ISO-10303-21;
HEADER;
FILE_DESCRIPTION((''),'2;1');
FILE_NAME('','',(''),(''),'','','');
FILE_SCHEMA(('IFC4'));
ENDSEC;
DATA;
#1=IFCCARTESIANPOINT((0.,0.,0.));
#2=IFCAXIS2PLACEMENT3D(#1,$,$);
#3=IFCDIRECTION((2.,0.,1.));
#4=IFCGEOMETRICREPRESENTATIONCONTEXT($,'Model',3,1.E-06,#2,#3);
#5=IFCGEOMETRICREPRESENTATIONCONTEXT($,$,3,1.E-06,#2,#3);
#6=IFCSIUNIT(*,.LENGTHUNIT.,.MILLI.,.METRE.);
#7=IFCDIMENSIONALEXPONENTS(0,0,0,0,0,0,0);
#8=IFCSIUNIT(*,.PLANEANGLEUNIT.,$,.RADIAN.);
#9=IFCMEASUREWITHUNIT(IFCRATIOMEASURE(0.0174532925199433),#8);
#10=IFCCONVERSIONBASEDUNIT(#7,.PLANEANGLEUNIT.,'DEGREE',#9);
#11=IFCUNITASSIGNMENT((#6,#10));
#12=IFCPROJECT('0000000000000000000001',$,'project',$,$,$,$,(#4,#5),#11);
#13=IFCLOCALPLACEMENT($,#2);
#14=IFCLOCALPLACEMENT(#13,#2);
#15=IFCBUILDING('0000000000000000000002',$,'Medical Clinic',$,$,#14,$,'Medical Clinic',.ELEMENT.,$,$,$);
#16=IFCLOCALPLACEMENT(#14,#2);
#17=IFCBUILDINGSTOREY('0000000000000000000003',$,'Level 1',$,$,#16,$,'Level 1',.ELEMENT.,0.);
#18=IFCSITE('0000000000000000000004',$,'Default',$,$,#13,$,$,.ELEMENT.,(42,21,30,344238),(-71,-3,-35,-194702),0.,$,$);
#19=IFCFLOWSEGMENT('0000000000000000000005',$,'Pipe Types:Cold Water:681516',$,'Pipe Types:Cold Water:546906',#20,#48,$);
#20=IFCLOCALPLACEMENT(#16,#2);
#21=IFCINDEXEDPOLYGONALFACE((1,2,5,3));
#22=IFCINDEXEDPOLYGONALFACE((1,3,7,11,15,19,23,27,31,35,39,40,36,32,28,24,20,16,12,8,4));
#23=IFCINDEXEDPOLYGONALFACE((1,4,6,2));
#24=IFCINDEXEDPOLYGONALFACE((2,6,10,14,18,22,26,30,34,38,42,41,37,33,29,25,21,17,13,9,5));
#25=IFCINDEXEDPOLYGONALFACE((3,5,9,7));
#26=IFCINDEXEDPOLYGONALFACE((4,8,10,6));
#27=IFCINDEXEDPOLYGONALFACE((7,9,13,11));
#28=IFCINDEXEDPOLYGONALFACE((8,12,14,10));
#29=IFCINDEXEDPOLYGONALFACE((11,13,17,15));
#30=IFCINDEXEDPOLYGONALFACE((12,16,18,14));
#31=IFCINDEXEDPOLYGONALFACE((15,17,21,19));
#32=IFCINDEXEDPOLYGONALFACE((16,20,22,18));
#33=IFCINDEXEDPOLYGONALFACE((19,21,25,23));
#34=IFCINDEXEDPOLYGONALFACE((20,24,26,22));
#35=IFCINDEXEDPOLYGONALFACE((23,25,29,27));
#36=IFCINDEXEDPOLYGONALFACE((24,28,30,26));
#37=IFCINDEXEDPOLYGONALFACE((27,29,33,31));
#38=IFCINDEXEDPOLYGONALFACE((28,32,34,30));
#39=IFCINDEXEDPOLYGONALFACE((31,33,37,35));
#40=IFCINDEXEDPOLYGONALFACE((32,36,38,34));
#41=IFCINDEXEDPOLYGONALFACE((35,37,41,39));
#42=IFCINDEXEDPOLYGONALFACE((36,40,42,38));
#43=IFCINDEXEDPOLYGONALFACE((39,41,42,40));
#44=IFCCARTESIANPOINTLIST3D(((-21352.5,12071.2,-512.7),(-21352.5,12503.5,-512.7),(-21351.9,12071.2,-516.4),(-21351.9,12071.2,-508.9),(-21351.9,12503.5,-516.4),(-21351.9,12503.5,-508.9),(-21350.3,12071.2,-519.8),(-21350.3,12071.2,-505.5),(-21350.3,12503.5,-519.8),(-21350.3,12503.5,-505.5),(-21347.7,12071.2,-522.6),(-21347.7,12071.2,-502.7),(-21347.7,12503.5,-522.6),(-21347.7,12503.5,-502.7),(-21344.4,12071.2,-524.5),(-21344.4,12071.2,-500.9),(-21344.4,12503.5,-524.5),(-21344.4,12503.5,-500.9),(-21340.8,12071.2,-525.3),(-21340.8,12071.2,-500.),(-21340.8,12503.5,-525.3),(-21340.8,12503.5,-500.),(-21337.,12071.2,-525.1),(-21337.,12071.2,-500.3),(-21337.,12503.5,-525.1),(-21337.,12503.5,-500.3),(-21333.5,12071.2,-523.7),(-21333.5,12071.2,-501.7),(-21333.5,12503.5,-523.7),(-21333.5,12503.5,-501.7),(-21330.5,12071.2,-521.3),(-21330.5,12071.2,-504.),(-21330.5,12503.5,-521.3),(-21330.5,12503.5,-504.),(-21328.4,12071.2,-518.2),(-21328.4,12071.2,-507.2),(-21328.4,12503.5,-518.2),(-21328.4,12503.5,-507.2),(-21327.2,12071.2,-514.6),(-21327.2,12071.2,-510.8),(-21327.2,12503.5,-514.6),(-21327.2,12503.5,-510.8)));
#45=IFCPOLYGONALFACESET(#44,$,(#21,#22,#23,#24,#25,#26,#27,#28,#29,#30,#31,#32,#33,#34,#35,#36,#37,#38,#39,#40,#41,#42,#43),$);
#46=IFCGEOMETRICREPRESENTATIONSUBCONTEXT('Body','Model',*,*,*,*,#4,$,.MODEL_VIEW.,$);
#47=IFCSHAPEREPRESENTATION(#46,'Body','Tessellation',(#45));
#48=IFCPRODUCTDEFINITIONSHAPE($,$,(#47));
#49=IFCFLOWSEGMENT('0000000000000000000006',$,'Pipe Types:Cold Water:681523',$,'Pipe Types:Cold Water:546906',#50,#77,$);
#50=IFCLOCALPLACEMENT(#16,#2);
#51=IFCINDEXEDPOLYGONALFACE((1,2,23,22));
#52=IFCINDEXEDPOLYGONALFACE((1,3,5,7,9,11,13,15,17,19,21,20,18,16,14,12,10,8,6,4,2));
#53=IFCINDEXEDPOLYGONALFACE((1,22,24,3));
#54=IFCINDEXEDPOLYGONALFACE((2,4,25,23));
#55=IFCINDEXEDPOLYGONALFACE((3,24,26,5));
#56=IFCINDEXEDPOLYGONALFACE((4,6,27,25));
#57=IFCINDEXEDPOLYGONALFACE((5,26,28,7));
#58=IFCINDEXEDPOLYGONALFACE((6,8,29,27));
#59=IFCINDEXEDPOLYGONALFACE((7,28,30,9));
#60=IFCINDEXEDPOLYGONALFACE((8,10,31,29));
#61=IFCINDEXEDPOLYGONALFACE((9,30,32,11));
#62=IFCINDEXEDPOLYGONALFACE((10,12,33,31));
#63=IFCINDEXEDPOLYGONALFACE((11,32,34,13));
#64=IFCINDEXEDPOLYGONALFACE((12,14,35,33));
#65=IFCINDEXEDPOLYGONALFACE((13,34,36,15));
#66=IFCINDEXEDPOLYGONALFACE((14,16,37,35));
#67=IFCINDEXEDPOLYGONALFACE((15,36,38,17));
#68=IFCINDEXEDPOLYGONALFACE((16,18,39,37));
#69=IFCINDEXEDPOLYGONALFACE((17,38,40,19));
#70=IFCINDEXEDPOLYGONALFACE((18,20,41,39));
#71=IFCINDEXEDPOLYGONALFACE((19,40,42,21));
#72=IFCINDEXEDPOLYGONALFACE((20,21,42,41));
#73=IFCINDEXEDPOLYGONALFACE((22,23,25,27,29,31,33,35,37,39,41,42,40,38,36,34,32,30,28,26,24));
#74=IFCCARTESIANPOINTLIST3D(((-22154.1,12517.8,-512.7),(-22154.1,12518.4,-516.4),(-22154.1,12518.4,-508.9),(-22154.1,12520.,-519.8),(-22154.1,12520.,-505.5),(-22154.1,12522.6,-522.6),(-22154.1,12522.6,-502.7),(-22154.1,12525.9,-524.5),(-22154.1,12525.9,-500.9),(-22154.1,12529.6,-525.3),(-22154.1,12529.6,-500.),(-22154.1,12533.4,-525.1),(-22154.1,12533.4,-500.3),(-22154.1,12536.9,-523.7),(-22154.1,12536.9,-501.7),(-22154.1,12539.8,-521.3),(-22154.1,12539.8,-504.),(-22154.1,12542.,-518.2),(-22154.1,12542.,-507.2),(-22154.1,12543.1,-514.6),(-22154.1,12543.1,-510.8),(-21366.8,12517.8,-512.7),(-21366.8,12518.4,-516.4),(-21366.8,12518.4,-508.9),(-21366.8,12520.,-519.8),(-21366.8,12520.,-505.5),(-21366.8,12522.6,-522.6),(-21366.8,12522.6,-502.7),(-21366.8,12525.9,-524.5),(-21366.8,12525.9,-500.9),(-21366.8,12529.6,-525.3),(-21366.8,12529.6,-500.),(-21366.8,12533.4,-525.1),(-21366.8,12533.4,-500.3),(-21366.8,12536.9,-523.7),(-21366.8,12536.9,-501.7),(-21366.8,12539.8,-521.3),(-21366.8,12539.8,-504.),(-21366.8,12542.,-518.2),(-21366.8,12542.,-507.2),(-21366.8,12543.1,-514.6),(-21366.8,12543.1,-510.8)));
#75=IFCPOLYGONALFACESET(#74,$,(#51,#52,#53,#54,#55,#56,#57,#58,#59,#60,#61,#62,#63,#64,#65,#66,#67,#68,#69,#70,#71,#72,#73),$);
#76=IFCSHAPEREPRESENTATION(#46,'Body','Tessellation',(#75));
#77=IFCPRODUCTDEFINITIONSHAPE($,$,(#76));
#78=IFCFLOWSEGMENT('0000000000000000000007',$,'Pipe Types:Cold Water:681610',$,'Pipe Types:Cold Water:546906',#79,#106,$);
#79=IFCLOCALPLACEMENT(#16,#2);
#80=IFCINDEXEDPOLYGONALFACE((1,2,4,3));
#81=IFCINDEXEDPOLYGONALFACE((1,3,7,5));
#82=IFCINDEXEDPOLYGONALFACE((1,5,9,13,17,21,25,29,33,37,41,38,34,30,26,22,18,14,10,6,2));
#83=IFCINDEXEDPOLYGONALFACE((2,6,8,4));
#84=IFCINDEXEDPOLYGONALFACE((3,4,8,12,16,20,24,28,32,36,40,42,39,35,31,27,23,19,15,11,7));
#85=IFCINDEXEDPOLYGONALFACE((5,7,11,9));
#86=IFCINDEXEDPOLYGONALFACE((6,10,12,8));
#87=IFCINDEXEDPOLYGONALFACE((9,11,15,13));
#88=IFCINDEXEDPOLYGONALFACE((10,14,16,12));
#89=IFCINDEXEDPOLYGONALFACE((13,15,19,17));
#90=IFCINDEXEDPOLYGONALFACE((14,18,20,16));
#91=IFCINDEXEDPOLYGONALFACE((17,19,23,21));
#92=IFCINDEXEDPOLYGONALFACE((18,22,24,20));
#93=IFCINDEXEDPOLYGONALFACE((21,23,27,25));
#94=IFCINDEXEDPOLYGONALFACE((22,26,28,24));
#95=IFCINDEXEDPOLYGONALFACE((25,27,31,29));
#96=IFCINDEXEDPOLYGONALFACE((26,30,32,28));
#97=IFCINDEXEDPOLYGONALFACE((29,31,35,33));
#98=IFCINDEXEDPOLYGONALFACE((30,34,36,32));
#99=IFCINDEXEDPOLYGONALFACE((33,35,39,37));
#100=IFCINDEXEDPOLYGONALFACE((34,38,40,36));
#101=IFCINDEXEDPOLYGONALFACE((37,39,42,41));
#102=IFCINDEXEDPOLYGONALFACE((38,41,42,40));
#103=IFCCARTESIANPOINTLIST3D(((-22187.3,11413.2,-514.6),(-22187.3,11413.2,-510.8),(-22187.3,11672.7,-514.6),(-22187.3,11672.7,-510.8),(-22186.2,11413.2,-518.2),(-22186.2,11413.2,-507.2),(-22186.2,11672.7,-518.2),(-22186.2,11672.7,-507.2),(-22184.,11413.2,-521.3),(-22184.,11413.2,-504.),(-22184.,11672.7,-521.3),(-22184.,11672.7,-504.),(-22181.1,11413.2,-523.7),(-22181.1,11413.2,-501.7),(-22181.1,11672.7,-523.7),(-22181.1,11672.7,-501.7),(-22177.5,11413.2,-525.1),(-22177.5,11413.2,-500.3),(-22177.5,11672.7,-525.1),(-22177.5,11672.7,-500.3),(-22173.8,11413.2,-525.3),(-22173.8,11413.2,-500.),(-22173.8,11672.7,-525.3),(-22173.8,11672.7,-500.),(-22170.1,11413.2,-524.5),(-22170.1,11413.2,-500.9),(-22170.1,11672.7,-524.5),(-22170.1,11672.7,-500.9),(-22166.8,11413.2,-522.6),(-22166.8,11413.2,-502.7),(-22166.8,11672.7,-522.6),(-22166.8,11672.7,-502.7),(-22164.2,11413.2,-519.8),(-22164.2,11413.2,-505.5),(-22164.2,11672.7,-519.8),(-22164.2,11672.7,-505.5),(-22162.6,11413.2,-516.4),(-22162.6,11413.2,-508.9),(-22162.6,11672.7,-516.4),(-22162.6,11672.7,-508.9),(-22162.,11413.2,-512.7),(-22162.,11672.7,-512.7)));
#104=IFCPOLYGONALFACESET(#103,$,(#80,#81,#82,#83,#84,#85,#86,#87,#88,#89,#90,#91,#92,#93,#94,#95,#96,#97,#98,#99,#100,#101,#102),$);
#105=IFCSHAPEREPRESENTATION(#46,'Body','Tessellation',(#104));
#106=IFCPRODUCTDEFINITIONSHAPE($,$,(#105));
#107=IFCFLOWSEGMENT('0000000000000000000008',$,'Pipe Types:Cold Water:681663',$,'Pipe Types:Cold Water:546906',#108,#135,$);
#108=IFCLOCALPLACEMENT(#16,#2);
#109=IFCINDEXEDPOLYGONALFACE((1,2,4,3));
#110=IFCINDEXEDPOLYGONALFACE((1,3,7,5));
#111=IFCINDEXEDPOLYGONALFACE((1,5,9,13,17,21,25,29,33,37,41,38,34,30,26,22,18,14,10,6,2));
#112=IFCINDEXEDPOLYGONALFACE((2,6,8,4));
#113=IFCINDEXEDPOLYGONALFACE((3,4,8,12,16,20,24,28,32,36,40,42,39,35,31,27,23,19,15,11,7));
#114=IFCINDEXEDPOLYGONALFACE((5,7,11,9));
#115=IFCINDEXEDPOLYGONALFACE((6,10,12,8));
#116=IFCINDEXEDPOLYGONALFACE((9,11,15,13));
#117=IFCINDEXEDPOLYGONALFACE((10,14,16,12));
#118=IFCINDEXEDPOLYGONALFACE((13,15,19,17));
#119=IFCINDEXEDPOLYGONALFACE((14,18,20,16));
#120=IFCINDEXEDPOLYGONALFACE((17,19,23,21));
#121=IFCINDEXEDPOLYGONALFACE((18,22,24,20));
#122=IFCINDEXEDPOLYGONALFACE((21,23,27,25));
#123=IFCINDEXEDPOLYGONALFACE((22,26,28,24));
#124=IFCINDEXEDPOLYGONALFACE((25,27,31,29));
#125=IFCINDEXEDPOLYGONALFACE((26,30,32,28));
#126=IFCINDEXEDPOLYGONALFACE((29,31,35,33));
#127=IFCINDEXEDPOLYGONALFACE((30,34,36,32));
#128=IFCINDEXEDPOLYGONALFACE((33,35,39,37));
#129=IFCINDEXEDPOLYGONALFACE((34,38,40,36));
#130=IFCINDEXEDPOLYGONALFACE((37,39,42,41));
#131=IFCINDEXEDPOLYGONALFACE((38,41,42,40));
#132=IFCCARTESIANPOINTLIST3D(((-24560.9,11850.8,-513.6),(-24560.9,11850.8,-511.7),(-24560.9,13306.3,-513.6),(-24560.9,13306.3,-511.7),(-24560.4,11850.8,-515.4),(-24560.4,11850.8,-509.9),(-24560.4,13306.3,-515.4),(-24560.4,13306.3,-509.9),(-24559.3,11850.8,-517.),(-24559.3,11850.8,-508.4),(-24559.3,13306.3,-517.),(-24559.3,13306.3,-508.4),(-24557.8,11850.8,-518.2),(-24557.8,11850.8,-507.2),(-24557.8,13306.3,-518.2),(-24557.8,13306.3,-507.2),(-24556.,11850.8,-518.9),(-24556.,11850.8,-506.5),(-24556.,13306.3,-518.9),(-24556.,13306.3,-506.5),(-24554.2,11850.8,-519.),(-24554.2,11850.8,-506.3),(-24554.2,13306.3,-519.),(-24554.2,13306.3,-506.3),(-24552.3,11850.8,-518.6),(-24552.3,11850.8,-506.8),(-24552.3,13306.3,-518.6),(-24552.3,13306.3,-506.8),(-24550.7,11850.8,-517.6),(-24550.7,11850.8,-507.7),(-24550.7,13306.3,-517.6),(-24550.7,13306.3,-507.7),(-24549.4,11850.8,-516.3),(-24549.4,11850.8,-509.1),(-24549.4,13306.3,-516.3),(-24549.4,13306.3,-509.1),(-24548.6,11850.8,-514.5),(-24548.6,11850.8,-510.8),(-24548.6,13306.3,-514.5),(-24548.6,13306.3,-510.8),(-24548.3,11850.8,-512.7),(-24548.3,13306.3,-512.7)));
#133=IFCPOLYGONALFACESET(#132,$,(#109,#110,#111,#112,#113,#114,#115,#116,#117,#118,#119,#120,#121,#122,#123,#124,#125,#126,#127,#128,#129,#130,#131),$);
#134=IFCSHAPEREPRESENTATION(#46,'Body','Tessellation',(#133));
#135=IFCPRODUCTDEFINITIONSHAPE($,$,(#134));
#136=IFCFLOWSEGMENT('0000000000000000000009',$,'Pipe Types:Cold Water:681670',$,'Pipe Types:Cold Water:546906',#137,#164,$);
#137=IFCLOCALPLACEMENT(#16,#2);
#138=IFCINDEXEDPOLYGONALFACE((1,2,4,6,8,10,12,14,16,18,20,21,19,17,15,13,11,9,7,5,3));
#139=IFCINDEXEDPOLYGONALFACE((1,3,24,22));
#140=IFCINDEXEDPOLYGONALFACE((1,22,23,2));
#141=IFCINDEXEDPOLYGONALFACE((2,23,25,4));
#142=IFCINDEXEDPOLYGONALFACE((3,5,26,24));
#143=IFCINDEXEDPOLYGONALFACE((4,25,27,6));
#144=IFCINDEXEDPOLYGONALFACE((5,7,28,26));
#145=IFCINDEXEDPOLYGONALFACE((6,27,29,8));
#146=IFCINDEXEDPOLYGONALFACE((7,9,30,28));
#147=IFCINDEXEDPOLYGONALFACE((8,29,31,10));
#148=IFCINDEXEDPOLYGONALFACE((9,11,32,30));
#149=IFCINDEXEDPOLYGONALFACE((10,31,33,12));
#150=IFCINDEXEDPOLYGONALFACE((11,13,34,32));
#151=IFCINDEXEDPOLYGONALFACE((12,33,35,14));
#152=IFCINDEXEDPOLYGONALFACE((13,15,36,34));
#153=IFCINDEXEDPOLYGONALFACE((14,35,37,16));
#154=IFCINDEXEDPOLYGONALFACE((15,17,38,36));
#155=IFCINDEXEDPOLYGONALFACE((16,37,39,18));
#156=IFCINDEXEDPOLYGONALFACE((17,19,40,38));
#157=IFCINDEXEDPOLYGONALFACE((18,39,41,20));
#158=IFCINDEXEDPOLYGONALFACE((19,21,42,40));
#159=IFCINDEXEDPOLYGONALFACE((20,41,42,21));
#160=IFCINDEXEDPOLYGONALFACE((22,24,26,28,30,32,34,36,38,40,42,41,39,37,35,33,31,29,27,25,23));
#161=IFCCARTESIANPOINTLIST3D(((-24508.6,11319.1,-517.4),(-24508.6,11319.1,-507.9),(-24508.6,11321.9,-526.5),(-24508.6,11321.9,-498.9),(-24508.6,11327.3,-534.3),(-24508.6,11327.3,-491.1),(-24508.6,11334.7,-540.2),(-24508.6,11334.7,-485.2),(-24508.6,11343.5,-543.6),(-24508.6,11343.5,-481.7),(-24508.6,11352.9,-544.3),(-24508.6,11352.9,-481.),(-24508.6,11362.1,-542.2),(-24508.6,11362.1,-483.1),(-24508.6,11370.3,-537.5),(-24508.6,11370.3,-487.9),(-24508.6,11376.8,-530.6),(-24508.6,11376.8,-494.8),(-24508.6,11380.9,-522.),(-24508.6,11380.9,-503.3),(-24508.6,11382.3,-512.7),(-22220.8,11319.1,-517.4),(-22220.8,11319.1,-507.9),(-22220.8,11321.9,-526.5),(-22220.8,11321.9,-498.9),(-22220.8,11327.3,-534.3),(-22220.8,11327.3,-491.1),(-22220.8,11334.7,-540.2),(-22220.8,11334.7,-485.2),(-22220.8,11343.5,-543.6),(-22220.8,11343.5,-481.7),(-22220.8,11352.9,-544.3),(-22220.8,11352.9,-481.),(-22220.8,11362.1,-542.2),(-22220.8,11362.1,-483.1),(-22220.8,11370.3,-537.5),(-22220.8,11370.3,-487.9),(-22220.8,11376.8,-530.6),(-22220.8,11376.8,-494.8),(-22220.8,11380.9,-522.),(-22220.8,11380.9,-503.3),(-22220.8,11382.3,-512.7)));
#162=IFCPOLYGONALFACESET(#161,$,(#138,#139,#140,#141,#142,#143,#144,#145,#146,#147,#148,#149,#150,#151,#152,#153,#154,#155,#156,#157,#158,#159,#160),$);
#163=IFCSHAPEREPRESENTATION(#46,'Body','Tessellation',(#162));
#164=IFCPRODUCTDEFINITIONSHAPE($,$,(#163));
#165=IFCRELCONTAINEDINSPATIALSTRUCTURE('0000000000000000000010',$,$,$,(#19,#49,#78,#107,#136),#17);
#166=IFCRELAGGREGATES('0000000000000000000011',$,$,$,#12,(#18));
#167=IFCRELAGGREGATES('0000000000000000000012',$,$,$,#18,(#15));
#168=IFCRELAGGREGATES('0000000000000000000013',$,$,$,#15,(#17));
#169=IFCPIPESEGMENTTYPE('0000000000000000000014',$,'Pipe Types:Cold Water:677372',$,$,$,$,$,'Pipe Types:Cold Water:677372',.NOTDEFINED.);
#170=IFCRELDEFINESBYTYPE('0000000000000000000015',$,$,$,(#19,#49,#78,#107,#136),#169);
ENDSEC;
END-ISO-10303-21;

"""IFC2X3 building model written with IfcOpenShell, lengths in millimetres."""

from ifc_helpers import new_model, entity, si_unit, converted_unit, direction, frame, frame_2d, origin, origin_2d_with_axis, place, context, subcontext, project, spatial, circle, extrude, type_object, element, save


model = new_model("IFC2X3")

# Units and contexts
model_context = context("Model", 3, precision=1e-06, world=origin(), true_north=direction((2.0, 0.0, 1.0)))
context_of_model = context(None, 3, precision=1e-06, world=origin(), true_north=direction((2.0, 0.0, 1.0)))
body_context = subcontext(model_context, "Body", "Model", "MODEL_VIEW")
ifc_project = project(units=[si_unit("LENGTHUNIT", "METRE", prefix="MILLI"), converted_unit("PLANEANGLEUNIT", "DEGREE", entity("IfcRatioMeasure", 0.0174532925199433), si_unit("PLANEANGLEUNIT", "RADIAN"), dimensions=[0, 0, 0, 0, 0, 0, 0])], contexts=[model_context, context_of_model])

# Site, building, storey
site_placement = place(None, origin())
site = spatial("IfcSite", under=ifc_project, at=site_placement, Name="Default", CompositionType="ELEMENT", RefLatitude=(42, 21, 30, 344238), RefLongitude=(-71, -3, -35, -194702), RefElevation=0.0)
building_placement = place(site_placement, origin())
building = spatial("IfcBuilding", under=site, at=building_placement, Name="Medical Clinic", LongName="Medical Clinic", CompositionType="ELEMENT")
storey_placement = place(building_placement, origin())
storey = spatial("IfcBuildingStorey", under=building, at=storey_placement, Name="Level 1", LongName="Level 1", CompositionType="ELEMENT", Elevation=0.0)

# Flow segments
pipe_segment_type_1 = type_object("IfcPipeSegmentType", Name="Pipe Types:Cold Water:677372", ElementType="Pipe Types:Cold Water:677372", PredefinedType="NOTDEFINED")
flow_segment_1_placement = place(storey_placement, origin())
element("IfcFlowSegment", 1, at=flow_segment_1_placement, inside=storey, type_object=pipe_segment_type_1, Name="Pipe Types:Cold Water:681516", ObjectType="Pipe Types:Cold Water:546906", context=body_context, shape_type="SweptSolid", body=[
    extrude(circle(Radius=12.7, at=frame_2d((0.0, 0.0), x_axis=(1.0, 0.0))), frame((-21339.8, 12071.2, -512.7), z_axis=(0.0, 1.0, 0.0), x_axis=(-1.0, 0.0, 0.0)), (0.0, 0.0, 1.0), 432.4),
])
flow_segment_2_placement = place(storey_placement, origin())
element("IfcFlowSegment", 2, at=flow_segment_2_placement, inside=storey, type_object=pipe_segment_type_1, Name="Pipe Types:Cold Water:681523", ObjectType="Pipe Types:Cold Water:546906", context=body_context, shape_type="SweptSolid", body=[
    extrude(circle(Radius=12.7, at=origin_2d_with_axis()), frame((-22154.1, 12530.5, -512.7), z_axis=(1.0, 0.0, 0.0), x_axis=(0.0, -1.0, 0.0)), (0.0, 0.0, 1.0), 787.3),
])
flow_segment_3_placement = place(storey_placement, origin())
element("IfcFlowSegment", 3, at=flow_segment_3_placement, inside=storey, type_object=pipe_segment_type_1, Name="Pipe Types:Cold Water:681610", ObjectType="Pipe Types:Cold Water:546906", context=body_context, shape_type="SweptSolid", body=[
    extrude(circle(Radius=12.7, at=frame_2d((0.0, 0.0), x_axis=(1.0, 0.0))), frame((-22174.7, 11413.2, -512.7), z_axis=(0.0, 1.0, 0.0), x_axis=(1.0, 0.0, 0.0)), (0.0, 0.0, 1.0), 259.4),
])
flow_segment_4_placement = place(storey_placement, origin())
element("IfcFlowSegment", 4, at=flow_segment_4_placement, inside=storey, type_object=pipe_segment_type_1, Name="Pipe Types:Cold Water:681663", ObjectType="Pipe Types:Cold Water:546906", context=body_context, shape_type="SweptSolid", body=[
    extrude(circle(Radius=6.3, at=frame_2d((0.0, 0.0), x_axis=(1.0, 0.0))), frame((-24554.6, 11850.8, -512.7), z_axis=(0.0, 1.0, 0.0), x_axis=(1.0, 0.0, 0.0)), (0.0, 0.0, 1.0), 1455.5),
])
flow_segment_5_placement = place(storey_placement, origin())
element("IfcFlowSegment", 5, at=flow_segment_5_placement, inside=storey, type_object=pipe_segment_type_1, Name="Pipe Types:Cold Water:681670", ObjectType="Pipe Types:Cold Water:546906", context=body_context, shape_type="SweptSolid", body=[
    extrude(circle(Radius=31.8, at=frame_2d((0.0, 0.0), x_axis=(1.0, 0.0))), frame((-24508.6, 11350.5, -512.7), z_axis=(1.0, 0.0, 0.0), x_axis=(0.0, 1.0, 0.0)), (0.0, 0.0, 1.0), 2287.8),
])

save(model, "model.ifc")
